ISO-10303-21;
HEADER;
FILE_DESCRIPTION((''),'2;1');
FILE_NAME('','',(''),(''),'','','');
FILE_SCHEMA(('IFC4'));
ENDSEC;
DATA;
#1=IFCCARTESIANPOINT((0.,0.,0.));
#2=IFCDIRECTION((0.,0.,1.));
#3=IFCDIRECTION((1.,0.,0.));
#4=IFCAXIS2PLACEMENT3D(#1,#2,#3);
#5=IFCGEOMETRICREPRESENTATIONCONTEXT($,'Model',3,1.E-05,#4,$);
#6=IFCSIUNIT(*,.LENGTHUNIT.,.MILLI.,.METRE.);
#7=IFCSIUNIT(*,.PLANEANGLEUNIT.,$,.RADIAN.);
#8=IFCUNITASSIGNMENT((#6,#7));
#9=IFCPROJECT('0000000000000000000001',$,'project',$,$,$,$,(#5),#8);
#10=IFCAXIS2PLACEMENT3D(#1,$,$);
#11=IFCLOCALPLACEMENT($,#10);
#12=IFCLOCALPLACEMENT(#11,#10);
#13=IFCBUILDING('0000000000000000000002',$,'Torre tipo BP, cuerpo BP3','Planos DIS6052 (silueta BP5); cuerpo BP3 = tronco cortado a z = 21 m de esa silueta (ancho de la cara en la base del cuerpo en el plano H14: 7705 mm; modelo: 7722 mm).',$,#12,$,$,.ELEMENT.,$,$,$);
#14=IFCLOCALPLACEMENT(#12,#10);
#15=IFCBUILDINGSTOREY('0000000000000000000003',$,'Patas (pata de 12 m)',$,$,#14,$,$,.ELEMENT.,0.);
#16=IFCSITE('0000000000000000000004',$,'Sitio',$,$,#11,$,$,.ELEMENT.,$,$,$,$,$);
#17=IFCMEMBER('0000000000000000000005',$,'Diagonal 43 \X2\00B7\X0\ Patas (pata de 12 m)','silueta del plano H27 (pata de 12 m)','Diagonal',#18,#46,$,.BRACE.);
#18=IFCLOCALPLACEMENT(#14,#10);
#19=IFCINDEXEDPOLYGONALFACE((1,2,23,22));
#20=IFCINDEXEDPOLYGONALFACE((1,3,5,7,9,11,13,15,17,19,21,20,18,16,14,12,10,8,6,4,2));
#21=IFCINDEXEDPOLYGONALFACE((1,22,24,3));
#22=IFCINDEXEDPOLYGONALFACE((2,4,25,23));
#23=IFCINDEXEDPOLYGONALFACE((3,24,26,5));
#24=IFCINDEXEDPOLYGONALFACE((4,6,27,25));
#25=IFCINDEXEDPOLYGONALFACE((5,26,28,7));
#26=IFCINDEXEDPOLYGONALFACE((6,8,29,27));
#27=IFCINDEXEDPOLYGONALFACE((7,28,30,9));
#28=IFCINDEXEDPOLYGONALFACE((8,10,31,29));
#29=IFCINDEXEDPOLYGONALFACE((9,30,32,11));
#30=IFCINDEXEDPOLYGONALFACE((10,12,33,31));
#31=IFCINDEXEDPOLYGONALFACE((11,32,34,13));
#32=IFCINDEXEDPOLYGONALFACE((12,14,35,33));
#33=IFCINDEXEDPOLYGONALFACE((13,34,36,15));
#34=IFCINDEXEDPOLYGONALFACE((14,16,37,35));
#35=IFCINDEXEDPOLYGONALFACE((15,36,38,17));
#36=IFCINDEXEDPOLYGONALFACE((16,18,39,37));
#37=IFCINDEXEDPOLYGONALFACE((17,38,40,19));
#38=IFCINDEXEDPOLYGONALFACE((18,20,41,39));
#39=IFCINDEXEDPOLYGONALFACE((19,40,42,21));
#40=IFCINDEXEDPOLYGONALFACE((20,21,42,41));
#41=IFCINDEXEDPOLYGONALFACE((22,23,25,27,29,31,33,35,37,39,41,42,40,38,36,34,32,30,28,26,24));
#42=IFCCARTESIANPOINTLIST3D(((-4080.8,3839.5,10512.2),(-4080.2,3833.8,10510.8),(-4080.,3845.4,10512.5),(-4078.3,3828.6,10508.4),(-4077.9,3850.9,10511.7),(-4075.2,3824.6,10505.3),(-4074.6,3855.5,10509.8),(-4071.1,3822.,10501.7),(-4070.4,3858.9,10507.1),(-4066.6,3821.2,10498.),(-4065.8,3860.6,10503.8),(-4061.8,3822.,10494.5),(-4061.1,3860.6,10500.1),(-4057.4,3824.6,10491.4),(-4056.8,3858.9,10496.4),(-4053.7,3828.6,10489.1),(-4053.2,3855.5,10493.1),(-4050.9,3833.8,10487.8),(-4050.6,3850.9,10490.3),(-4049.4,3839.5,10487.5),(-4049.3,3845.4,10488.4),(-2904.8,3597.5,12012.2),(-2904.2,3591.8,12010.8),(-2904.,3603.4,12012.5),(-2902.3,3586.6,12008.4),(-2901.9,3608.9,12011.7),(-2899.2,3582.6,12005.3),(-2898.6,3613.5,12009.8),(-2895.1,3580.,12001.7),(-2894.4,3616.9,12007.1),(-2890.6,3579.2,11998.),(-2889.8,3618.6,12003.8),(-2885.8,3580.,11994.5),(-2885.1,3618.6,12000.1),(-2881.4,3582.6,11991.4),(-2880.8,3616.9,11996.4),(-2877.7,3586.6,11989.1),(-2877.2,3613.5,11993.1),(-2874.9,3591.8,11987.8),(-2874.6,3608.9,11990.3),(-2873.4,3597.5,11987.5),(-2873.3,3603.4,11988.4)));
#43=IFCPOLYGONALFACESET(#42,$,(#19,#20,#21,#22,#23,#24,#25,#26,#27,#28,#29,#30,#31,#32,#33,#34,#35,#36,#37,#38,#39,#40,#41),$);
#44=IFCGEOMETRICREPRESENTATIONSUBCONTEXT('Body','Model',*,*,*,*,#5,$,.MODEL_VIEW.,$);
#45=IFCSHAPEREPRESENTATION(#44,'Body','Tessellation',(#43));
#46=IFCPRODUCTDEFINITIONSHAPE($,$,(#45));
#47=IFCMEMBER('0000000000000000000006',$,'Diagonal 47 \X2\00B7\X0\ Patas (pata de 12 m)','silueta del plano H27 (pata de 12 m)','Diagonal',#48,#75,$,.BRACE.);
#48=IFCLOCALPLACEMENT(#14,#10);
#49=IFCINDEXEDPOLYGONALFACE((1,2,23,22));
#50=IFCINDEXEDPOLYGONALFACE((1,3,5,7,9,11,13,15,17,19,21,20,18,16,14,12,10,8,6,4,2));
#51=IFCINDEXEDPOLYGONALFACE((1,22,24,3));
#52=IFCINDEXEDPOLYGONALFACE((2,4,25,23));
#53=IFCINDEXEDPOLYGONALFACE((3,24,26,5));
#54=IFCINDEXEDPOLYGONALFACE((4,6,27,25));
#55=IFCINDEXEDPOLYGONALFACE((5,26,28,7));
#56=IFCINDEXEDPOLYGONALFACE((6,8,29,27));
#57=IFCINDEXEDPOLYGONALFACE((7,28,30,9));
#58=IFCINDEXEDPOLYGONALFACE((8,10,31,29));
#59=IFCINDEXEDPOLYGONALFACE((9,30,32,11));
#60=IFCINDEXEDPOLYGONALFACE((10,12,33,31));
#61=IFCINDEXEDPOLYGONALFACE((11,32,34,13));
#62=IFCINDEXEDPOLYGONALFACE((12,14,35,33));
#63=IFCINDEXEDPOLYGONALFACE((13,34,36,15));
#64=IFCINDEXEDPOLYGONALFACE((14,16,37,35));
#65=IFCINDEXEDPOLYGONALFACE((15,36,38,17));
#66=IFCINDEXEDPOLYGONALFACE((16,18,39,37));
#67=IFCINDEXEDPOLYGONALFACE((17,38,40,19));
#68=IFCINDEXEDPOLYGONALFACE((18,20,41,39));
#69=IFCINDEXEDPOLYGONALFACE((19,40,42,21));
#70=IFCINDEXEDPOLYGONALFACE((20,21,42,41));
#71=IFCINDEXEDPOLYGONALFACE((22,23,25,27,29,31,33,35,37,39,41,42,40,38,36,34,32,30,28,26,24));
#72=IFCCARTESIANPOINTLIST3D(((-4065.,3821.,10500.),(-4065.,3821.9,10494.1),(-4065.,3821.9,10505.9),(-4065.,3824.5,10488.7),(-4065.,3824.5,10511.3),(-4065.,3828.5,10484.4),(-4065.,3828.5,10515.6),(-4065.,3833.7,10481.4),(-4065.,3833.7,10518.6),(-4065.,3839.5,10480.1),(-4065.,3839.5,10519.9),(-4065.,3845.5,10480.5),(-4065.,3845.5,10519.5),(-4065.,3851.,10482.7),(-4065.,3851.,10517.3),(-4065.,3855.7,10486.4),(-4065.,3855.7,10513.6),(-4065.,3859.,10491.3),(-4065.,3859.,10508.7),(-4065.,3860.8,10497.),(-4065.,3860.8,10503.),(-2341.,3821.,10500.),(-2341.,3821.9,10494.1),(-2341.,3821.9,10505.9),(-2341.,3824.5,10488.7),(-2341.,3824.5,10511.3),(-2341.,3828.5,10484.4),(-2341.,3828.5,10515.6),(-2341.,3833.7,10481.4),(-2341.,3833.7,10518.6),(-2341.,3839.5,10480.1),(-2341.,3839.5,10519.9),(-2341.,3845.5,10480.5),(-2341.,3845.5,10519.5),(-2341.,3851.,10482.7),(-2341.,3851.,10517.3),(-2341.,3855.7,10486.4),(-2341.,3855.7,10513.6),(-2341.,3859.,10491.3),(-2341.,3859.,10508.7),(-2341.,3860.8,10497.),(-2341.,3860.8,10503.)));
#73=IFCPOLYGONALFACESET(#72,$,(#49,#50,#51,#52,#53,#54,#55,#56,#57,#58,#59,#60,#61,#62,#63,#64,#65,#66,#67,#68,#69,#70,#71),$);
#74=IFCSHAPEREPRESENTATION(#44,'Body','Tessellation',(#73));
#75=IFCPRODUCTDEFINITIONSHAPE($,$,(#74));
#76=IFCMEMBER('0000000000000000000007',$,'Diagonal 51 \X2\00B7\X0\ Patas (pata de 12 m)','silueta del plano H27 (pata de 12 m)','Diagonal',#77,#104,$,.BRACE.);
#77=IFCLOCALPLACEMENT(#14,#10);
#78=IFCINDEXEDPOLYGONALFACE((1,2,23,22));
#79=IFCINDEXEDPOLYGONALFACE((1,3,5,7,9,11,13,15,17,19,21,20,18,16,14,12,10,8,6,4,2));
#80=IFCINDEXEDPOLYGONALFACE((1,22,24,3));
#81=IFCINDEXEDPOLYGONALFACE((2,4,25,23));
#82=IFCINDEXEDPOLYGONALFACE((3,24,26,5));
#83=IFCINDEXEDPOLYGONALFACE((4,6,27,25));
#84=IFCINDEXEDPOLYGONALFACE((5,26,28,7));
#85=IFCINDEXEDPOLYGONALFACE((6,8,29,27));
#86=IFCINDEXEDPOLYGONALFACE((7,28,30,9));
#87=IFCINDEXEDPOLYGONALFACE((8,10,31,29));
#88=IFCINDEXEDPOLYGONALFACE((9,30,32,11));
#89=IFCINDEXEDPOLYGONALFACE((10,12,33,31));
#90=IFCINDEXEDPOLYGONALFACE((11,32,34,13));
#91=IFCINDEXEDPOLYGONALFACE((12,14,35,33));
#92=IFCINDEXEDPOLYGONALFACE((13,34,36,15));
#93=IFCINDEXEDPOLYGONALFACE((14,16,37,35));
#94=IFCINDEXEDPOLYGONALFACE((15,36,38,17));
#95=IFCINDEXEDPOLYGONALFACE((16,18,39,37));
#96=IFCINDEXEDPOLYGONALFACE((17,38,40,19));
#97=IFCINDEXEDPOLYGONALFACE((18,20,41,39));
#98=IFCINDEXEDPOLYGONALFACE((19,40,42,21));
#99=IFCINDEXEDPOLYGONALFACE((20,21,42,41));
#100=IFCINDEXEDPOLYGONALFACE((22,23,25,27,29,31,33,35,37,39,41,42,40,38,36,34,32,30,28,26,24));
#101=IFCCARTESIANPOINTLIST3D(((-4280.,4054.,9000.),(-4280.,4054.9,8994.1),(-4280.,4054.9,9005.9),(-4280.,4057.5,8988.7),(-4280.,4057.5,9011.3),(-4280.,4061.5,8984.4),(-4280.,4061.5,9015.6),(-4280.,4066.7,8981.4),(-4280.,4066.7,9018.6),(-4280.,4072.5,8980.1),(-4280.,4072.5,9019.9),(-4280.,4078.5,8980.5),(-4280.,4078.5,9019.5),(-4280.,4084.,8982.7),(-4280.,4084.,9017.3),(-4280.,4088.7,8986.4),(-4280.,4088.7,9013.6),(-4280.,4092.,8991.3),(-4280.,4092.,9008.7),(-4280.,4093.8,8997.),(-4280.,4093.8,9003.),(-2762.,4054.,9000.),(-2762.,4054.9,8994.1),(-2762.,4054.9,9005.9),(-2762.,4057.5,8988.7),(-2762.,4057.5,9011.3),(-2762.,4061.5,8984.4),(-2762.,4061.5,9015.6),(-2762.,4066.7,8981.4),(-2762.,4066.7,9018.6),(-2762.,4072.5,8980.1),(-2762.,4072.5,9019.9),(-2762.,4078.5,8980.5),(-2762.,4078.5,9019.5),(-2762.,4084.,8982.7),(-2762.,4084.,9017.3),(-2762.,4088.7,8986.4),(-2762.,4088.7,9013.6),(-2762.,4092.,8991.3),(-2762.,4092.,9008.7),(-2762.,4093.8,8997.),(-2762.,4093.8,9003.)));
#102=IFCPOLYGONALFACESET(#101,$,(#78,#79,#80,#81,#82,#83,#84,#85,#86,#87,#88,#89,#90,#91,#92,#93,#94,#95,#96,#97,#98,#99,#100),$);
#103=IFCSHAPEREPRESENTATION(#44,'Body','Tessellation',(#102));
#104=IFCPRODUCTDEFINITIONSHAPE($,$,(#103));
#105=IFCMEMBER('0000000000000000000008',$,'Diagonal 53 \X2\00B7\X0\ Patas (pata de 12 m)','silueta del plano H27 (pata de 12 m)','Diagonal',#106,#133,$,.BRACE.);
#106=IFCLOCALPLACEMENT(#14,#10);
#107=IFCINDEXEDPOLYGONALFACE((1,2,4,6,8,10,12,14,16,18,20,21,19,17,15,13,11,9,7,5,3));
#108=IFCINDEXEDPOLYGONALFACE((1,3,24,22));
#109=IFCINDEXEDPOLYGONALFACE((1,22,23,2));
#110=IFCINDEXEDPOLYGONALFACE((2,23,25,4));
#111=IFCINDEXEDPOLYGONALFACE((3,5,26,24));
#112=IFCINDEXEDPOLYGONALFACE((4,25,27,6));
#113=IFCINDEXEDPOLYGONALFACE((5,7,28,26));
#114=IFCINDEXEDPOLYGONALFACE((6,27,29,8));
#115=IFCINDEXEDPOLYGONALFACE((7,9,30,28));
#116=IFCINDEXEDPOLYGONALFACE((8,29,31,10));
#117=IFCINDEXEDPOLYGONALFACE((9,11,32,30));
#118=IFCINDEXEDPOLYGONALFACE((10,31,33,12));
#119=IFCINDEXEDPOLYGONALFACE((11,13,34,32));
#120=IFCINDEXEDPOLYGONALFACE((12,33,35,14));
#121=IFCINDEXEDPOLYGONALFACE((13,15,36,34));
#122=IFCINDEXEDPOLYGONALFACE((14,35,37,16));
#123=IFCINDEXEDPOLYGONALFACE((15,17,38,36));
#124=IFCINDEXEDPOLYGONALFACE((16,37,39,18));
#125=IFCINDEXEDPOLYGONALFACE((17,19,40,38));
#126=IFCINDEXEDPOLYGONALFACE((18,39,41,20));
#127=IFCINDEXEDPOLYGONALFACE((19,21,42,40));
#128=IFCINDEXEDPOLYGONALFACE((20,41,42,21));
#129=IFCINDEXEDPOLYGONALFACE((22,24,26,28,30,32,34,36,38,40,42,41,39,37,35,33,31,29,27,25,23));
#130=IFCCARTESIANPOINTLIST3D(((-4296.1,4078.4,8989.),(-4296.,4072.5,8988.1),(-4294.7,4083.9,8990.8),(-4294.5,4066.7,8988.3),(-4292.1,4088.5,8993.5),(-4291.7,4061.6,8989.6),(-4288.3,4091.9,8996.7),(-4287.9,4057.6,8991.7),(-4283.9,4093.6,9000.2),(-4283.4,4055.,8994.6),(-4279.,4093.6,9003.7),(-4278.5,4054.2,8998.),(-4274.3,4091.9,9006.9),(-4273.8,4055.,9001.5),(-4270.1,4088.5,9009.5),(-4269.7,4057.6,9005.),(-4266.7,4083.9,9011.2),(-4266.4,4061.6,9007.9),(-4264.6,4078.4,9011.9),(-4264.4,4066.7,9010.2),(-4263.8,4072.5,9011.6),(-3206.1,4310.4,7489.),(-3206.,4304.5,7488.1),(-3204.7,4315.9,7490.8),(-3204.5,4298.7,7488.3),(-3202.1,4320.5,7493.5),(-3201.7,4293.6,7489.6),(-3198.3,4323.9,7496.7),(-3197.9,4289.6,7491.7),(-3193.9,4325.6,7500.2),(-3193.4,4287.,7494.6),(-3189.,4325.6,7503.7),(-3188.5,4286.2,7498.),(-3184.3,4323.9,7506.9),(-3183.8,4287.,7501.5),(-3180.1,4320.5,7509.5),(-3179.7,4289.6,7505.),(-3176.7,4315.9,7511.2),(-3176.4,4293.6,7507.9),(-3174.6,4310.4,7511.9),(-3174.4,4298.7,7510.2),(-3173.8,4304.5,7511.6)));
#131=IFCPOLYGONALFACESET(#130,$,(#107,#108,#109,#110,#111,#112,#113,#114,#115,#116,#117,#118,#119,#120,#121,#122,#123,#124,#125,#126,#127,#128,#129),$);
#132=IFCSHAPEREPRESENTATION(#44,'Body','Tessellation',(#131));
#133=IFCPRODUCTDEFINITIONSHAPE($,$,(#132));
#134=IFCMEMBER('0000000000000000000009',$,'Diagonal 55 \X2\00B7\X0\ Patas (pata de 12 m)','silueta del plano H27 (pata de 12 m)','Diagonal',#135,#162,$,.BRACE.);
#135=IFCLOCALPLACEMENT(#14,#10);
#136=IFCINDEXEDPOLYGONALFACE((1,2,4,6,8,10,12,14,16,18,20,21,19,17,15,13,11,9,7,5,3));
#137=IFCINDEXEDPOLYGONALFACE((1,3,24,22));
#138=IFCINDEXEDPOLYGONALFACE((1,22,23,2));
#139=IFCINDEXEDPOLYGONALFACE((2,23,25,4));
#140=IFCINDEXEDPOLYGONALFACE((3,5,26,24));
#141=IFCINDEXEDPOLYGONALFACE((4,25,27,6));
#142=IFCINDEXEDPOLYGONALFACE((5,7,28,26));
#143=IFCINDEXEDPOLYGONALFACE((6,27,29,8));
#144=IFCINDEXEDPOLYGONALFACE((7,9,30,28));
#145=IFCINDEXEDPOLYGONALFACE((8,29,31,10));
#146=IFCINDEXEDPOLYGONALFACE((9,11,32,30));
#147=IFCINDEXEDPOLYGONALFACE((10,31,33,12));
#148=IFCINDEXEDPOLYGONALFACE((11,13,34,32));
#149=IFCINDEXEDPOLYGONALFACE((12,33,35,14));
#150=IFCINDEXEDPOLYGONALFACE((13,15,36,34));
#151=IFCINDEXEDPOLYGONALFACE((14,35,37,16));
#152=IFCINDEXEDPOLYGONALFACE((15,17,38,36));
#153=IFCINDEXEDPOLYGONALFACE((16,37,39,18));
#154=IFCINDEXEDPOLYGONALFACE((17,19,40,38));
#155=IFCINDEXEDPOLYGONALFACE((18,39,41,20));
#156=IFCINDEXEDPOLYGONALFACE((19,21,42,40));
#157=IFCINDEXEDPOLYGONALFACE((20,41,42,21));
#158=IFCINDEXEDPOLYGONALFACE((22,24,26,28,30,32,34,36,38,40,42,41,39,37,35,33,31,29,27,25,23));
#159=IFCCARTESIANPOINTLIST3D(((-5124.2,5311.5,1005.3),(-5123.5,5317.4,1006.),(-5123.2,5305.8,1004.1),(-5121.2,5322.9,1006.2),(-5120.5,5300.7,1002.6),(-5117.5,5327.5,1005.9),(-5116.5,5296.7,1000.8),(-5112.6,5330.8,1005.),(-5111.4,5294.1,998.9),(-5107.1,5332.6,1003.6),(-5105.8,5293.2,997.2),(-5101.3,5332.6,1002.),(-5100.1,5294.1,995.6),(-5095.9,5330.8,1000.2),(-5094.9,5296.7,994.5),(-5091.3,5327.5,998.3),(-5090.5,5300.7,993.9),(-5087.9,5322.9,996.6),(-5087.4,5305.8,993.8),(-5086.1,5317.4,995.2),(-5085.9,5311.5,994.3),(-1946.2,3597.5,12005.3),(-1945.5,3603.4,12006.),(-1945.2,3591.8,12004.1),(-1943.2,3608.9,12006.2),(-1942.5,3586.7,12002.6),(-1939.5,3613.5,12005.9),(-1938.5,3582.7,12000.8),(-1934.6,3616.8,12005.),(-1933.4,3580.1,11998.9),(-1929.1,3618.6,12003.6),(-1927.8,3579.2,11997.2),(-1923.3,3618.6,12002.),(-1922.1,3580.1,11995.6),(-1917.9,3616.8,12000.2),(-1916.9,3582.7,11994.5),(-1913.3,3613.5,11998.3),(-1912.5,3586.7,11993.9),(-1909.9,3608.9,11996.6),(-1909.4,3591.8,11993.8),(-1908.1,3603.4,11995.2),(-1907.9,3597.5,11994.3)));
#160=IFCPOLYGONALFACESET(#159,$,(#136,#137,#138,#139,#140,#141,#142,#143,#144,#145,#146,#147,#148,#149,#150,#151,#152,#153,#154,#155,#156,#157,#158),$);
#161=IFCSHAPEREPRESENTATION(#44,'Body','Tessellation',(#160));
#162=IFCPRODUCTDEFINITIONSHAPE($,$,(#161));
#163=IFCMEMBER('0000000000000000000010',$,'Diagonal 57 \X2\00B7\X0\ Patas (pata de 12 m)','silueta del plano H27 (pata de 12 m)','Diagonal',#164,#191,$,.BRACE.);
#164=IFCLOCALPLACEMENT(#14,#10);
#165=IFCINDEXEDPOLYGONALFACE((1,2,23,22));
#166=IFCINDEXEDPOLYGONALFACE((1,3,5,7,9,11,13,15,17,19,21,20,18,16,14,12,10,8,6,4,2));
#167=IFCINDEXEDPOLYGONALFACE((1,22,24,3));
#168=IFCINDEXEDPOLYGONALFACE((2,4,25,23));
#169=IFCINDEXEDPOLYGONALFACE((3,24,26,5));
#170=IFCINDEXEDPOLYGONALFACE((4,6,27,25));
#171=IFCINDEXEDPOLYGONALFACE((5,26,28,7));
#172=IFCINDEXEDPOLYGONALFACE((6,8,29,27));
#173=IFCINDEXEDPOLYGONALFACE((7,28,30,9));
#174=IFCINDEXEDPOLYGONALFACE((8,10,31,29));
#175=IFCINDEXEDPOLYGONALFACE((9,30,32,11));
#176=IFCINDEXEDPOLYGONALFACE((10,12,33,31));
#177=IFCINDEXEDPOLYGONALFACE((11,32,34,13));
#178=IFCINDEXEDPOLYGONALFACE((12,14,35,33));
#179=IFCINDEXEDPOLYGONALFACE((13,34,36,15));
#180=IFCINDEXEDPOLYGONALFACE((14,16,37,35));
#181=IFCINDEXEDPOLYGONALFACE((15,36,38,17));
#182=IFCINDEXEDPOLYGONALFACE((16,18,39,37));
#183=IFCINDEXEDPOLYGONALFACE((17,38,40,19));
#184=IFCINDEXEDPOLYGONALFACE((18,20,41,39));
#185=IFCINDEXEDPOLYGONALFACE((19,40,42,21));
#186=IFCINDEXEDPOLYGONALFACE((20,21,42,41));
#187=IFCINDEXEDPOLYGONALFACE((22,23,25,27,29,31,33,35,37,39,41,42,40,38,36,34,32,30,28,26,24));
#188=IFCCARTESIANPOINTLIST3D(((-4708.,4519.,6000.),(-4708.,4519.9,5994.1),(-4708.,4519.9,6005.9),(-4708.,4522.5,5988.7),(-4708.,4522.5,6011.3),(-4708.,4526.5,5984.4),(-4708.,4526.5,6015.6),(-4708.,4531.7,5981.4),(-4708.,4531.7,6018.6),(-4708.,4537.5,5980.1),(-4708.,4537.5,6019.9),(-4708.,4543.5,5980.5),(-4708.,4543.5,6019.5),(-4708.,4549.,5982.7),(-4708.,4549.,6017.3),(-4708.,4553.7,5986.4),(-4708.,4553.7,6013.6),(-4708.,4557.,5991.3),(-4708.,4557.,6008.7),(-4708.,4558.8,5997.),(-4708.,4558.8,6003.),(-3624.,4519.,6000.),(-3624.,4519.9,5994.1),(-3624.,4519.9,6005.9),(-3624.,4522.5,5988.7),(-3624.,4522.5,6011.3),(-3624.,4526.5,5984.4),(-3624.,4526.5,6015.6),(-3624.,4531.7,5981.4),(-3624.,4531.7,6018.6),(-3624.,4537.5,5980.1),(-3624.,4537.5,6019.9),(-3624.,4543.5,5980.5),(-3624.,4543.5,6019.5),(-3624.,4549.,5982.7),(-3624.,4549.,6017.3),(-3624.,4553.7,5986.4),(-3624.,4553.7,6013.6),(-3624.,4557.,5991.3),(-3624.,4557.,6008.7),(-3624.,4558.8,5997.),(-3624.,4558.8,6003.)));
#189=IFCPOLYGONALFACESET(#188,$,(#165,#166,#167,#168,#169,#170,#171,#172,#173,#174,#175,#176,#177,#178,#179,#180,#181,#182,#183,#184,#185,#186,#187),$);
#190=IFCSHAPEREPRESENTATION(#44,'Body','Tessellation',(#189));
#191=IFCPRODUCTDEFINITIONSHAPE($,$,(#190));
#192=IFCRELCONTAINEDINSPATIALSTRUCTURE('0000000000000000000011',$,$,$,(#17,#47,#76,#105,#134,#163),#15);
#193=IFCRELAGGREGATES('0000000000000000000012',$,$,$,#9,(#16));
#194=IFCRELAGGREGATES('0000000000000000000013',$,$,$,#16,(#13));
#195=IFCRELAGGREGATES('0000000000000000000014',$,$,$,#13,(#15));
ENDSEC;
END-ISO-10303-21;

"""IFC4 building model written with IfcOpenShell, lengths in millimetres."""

from ifc_helpers import new_model, si_unit, frame, origin, origin_with_axes, place, context, subcontext, project, spatial, circle, extrude, element, save


model = new_model("IFC4")

# Units and contexts
model_context = context("Model", 3, precision=1e-05, world=origin_with_axes())
body_context = subcontext(model_context, "Body", "Model", "MODEL_VIEW")
ifc_project = project(units=[si_unit("LENGTHUNIT", "METRE", prefix="MILLI"), si_unit("PLANEANGLEUNIT", "RADIAN")], contexts=[model_context])

# Site, building, storey
site_placement = place(None, origin())
site = spatial("IfcSite", under=ifc_project, at=site_placement, Name="Sitio", CompositionType="ELEMENT")
building_placement = place(site_placement, origin())
building = spatial("IfcBuilding", under=site, at=building_placement, Name="Torre tipo BP, cuerpo BP3", Description="Planos DIS6052 (silueta BP5); cuerpo BP3 = tronco cortado a z = 21 m de esa silueta (ancho de la cara en la base del cuerpo en el plano H14: 7705 mm; modelo: 7722 mm).", CompositionType="ELEMENT")
storey_placement = place(building_placement, origin())
storey = spatial("IfcBuildingStorey", under=building, at=storey_placement, Name="Patas (pata de 12 m)", CompositionType="ELEMENT", Elevation=0.0)

# Members
member_1_placement = place(storey_placement, frame((-4065.0, 3841.0, 10500.0), z_axis=(0.612073, -0.125954, 0.780706), x_axis=(-0.077712, -0.992036, -0.099122)))
element("IfcMember", 1, at=member_1_placement, inside=storey, Name="Diagonal 43 · Patas (pata de 12 m)", Description="silueta del plano H27 (pata de 12 m)", ObjectType="Diagonal", PredefinedType="BRACE", context=body_context, shape_type="SweptSolid", body=[
    extrude(circle(Radius=20.0), None, (0.0, 0.0, 1.0), 1921.3),
])
member_2_placement = place(storey_placement, frame((-2341.0, 3841.0, 10500.0), z_axis=(-1.0, 0.0, 0.0), x_axis=(0.0, -1.0, 0.0)))
element("IfcMember", 2, at=member_2_placement, inside=storey, Name="Diagonal 47 · Patas (pata de 12 m)", Description="silueta del plano H27 (pata de 12 m)", ObjectType="Diagonal", PredefinedType="BRACE", context=body_context, shape_type="SweptSolid", body=[
    extrude(circle(Radius=20.0), None, (0.0, 0.0, 1.0), 1724.0),
])
member_3_placement = place(storey_placement, frame((-4280.0, 4074.0, 9000.0), z_axis=(1.0, 0.0, 0.0), x_axis=(0.0, -1.0, 0.0)))
element("IfcMember", 3, at=member_3_placement, inside=storey, Name="Diagonal 51 · Patas (pata de 12 m)", Description="silueta del plano H27 (pata de 12 m)", ObjectType="Diagonal", PredefinedType="BRACE", context=body_context, shape_type="SweptSolid", body=[
    extrude(circle(Radius=20.0), None, (0.0, 0.0, 1.0), 1518.0),
])
member_4_placement = place(storey_placement, frame((-3190.0, 4306.0, 7500.0), z_axis=(-0.583303, -0.124153, 0.80271), x_axis=(0.072983, -0.992263, -0.100436)))
element("IfcMember", 4, at=member_4_placement, inside=storey, Name="Diagonal 53 · Patas (pata de 12 m)", Description="silueta del plano H27 (pata de 12 m)", ObjectType="Diagonal", PredefinedType="BRACE", context=body_context, shape_type="SweptSolid", body=[
    extrude(circle(Radius=20.0), None, (0.0, 0.0, 1.0), 1868.7),
])
member_5_placement = place(storey_placement, frame((-1927.0, 3599.0, 12000.0), z_axis=(-0.274499, 0.148046, -0.950122), x_axis=(-0.041091, -0.98898, -0.142229)))
element("IfcMember", 5, at=member_5_placement, inside=storey, Name="Diagonal 55 · Patas (pata de 12 m)", Description="silueta del plano H27 (pata de 12 m)", ObjectType="Diagonal", PredefinedType="BRACE", context=body_context, shape_type="SweptSolid", body=[
    extrude(circle(Radius=20.0), None, (0.0, 0.0, 1.0), 11577.5),
])
member_6_placement = place(storey_placement, frame((-4708.0, 4539.0, 6000.0), z_axis=(1.0, 0.0, 0.0), x_axis=(0.0, -1.0, 0.0)))
element("IfcMember", 6, at=member_6_placement, inside=storey, Name="Diagonal 57 · Patas (pata de 12 m)", Description="silueta del plano H27 (pata de 12 m)", ObjectType="Diagonal", PredefinedType="BRACE", context=body_context, shape_type="SweptSolid", body=[
    extrude(circle(Radius=20.0), None, (0.0, 0.0, 1.0), 1084.0),
])

save(model, "model.ifc")
